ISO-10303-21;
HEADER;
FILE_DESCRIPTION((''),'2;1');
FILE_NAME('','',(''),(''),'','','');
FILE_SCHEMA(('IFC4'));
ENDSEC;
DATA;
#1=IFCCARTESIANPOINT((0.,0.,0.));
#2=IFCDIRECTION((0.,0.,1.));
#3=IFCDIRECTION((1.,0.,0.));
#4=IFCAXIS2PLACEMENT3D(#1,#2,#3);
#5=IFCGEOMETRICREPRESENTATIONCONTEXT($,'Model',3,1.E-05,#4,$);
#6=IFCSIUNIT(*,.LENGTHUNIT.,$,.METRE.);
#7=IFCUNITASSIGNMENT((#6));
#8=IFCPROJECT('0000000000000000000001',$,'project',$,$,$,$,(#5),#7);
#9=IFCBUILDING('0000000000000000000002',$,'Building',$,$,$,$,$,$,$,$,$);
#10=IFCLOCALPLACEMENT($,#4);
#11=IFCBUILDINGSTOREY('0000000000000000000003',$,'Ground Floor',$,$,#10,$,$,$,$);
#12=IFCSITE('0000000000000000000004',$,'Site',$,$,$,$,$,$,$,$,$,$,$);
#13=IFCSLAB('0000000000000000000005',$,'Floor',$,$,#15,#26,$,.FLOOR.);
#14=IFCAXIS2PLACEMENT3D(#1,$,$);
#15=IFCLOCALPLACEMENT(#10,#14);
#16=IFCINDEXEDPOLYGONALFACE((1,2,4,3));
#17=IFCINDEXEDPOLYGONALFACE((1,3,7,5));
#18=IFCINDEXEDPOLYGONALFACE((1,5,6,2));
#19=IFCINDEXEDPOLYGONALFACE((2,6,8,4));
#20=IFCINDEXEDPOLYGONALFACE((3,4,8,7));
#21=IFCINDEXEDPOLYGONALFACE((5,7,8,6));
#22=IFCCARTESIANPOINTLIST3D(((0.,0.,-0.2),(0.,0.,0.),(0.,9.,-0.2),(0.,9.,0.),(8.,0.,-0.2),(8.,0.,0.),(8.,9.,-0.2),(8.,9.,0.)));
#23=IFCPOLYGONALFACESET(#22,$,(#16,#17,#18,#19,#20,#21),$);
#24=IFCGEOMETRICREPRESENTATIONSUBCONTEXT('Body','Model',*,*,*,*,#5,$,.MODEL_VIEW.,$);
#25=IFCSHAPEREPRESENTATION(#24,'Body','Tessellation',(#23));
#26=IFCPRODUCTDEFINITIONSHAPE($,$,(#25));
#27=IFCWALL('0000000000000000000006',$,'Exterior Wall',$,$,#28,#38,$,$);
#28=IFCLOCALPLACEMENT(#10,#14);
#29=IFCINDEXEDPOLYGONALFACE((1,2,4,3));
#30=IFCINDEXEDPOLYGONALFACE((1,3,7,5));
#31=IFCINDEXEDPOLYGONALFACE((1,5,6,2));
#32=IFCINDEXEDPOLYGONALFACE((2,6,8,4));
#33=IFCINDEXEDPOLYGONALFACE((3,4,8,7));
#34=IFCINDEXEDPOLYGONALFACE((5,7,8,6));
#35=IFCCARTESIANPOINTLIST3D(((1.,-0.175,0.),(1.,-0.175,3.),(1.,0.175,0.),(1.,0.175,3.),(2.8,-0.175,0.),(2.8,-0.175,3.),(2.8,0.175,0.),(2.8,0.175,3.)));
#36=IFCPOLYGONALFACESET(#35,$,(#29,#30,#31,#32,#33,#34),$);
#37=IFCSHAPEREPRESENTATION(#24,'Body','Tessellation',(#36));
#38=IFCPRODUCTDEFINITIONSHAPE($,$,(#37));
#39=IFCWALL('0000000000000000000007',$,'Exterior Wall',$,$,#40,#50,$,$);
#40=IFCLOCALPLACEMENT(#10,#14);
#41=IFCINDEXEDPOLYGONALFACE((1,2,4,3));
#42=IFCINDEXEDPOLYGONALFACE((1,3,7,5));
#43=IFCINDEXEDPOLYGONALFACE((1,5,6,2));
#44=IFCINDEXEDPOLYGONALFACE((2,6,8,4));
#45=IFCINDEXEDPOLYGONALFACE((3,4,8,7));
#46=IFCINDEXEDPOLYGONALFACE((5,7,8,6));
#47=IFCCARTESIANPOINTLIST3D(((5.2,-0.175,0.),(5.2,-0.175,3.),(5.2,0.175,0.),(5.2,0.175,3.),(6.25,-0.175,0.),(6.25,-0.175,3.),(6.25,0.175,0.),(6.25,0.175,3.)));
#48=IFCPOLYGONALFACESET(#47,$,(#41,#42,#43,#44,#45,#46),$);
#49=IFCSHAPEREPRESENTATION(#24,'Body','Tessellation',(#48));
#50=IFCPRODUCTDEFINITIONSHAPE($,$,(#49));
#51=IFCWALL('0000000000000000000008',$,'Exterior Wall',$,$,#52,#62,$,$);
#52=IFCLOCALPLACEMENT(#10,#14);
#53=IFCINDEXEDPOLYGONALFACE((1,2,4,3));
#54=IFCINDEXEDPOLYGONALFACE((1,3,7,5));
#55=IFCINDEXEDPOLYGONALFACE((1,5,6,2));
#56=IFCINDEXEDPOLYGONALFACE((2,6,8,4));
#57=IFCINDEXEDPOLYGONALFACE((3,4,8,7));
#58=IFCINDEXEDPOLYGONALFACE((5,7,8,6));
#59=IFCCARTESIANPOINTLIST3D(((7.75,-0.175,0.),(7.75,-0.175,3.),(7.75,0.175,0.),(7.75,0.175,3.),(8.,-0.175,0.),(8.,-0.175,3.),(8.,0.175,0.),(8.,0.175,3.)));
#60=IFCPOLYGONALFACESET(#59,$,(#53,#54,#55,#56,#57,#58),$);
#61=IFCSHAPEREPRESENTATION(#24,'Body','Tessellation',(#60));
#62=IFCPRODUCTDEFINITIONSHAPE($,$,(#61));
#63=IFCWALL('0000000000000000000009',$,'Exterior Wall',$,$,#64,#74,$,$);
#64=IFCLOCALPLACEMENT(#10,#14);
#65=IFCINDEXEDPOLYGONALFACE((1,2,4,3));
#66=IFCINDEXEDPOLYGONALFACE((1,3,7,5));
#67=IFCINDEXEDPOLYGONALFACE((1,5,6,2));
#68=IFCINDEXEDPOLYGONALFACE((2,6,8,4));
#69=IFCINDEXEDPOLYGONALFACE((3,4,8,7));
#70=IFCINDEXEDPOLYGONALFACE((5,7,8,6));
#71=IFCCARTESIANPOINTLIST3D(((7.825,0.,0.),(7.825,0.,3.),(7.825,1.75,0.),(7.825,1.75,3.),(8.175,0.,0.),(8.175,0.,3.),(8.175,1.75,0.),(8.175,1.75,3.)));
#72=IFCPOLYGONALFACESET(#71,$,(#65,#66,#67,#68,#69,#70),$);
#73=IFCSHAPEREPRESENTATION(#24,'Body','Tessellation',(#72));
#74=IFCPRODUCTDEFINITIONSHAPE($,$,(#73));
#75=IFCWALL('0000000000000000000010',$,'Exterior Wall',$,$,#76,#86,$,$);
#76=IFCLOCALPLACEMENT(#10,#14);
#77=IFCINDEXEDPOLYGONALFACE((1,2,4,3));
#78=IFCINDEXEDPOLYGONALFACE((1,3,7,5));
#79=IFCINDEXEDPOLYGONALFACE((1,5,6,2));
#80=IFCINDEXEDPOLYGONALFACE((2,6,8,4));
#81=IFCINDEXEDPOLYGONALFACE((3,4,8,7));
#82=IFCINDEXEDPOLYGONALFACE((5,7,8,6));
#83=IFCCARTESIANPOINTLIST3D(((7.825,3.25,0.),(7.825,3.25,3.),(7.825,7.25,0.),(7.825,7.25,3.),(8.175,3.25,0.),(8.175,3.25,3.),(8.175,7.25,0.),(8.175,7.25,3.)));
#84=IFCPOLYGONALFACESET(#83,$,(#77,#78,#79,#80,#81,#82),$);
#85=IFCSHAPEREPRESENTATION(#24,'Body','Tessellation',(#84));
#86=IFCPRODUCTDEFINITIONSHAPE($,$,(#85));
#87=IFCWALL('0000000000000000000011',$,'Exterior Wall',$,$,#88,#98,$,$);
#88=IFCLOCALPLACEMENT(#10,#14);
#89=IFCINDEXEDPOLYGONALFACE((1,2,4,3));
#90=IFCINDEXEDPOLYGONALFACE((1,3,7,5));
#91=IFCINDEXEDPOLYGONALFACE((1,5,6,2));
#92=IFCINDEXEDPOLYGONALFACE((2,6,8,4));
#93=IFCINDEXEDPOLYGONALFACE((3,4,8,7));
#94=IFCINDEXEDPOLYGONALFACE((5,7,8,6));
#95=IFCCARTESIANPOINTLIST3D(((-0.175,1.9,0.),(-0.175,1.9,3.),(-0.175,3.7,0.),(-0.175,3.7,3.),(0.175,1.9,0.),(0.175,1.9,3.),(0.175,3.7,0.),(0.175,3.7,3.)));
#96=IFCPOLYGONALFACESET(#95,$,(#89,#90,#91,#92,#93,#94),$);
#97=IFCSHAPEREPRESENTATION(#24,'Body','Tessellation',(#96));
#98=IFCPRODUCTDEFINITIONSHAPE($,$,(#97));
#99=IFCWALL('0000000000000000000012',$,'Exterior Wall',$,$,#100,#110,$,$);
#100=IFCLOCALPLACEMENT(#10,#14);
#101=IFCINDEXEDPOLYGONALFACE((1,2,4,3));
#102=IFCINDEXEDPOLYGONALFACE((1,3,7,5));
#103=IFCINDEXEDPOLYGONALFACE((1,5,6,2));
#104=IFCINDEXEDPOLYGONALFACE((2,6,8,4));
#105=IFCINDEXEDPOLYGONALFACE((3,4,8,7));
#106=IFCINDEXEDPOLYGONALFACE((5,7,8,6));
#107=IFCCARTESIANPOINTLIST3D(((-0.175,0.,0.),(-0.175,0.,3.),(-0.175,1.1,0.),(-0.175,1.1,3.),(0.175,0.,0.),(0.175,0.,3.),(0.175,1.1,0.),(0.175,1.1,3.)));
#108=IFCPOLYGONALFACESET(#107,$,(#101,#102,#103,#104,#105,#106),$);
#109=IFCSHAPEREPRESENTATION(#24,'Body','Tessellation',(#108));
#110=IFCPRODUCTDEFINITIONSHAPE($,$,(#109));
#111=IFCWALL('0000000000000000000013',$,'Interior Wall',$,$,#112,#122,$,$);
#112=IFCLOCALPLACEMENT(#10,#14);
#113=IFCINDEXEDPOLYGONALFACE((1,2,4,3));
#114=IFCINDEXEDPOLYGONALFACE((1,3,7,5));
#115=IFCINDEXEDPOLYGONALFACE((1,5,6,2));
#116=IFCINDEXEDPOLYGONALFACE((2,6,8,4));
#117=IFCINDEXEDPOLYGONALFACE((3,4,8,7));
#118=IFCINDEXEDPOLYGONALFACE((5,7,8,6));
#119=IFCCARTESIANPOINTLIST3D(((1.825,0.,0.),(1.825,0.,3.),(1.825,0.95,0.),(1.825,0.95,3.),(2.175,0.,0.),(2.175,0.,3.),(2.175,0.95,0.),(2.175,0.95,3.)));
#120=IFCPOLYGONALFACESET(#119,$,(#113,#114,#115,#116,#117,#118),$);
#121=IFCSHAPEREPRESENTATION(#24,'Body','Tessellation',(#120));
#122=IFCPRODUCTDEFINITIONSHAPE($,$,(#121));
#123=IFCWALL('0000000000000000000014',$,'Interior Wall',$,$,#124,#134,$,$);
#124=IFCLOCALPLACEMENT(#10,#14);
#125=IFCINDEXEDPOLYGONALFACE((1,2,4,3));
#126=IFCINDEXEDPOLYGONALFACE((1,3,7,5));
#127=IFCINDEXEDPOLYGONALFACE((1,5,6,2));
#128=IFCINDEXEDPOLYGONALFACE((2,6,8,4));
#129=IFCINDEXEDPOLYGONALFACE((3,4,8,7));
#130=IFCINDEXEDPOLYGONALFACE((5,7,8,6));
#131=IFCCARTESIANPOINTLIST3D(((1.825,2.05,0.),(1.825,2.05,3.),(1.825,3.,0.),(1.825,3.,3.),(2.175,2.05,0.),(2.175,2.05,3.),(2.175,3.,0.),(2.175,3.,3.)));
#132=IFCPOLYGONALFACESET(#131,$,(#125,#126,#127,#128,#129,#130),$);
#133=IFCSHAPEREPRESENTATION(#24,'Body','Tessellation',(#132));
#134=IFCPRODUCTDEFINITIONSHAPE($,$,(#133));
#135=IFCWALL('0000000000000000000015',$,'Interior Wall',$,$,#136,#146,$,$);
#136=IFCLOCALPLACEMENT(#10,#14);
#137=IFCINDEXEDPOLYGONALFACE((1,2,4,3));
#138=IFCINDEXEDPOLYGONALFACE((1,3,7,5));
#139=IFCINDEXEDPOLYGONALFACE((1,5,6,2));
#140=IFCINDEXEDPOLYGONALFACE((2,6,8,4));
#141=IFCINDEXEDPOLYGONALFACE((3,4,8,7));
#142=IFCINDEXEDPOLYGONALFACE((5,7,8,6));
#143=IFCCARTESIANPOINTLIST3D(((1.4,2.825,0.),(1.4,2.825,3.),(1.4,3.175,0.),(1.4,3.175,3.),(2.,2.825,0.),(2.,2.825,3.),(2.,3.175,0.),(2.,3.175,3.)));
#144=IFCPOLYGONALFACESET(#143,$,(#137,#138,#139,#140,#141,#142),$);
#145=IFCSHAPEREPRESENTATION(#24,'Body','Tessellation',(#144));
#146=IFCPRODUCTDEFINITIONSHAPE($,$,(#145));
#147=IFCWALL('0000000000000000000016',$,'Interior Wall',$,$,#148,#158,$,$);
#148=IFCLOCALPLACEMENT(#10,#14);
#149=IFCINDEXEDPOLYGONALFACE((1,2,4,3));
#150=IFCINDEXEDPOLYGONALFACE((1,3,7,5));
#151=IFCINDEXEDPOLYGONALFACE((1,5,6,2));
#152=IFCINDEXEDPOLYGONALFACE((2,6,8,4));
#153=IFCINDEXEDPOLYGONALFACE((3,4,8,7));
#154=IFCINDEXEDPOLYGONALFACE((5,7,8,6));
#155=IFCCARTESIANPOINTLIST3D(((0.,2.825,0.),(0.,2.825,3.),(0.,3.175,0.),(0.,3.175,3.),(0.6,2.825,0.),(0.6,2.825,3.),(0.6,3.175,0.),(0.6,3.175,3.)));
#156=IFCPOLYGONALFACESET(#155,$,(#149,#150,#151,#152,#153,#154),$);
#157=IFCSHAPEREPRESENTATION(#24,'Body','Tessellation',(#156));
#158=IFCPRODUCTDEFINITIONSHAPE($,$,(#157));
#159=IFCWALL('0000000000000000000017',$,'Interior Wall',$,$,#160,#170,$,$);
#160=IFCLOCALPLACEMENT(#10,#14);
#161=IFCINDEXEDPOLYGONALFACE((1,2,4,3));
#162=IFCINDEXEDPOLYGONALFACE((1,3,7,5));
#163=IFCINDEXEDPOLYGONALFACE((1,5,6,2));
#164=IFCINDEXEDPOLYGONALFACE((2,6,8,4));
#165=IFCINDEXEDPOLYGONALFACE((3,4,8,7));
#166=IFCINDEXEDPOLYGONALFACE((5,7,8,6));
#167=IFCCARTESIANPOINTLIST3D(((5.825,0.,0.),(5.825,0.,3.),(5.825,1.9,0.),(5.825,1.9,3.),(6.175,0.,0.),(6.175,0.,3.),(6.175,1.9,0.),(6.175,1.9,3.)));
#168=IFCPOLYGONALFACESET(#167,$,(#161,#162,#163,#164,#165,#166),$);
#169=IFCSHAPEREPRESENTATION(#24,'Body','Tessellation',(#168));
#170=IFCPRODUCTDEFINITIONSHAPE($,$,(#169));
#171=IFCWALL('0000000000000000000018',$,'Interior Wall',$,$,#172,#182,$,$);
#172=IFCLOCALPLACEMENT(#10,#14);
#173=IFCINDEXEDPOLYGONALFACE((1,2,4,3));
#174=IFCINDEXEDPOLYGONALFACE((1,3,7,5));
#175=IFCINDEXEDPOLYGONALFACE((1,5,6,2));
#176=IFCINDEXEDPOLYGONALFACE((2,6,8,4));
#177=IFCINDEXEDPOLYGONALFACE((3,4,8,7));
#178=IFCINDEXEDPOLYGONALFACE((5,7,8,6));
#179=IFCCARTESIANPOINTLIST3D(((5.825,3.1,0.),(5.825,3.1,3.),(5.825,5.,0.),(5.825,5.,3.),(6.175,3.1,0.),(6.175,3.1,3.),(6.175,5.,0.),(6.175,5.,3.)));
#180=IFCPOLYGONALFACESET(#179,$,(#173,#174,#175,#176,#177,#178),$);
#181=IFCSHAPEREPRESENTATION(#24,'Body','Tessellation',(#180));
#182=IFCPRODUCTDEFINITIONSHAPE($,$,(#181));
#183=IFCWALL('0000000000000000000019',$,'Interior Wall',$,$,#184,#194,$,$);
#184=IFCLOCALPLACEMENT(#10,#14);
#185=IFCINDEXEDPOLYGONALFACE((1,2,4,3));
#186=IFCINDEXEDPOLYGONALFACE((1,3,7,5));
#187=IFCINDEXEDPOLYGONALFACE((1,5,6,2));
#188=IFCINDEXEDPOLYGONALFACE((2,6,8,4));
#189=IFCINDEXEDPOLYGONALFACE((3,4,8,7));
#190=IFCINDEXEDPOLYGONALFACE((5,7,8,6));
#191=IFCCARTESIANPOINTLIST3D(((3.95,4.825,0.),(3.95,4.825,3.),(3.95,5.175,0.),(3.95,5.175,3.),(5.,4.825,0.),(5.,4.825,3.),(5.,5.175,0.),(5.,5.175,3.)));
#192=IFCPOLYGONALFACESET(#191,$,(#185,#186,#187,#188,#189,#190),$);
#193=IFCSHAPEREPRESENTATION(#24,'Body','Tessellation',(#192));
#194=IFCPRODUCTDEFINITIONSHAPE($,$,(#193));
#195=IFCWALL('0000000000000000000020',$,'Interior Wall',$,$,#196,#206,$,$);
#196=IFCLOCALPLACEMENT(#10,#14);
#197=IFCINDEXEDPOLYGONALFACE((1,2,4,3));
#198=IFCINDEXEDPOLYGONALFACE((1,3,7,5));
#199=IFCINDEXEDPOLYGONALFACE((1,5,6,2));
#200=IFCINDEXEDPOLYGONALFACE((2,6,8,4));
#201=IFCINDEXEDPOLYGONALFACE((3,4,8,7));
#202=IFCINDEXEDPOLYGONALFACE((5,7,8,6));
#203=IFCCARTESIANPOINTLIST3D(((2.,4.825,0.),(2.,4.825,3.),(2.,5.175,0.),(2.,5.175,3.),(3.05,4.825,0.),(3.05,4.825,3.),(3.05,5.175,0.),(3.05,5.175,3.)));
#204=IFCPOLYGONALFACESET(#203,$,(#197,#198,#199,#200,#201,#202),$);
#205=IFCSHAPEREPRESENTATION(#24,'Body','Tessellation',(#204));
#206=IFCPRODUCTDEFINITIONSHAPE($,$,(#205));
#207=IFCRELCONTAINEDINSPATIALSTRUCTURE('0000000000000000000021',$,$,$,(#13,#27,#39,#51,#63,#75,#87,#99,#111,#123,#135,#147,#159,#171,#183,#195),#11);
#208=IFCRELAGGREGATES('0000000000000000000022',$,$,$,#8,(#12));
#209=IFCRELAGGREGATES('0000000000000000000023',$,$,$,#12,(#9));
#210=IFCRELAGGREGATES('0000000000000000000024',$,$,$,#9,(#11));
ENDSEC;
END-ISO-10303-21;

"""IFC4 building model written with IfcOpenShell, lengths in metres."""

from ifc_helpers import new_model, si_unit, frame, origin_with_axes, place, context, subcontext, project, spatial, indexed_curve, outline, extrude, element, save


model = new_model("IFC4")

# Units and contexts
model_context = context("Model", 3, precision=1e-05, world=origin_with_axes())
body_context = subcontext(model_context, "Body", "Model", "MODEL_VIEW")
ifc_project = project(units=[si_unit("LENGTHUNIT", "METRE")], contexts=[model_context])

# Site, building, storey
site = spatial("IfcSite", under=ifc_project, Name="Site")
building = spatial("IfcBuilding", under=site, Name="Building")
storey_placement = place(None, origin_with_axes())
storey = spatial("IfcBuildingStorey", under=building, at=storey_placement, Name="Ground Floor")

# Slab
slab_placement = place(storey_placement, frame((0.0, 0.0, -0.2), z_axis=(0.0, 0.0, 1.0), x_axis=(1.0, 0.0, 0.0)))
element("IfcSlab", 1, at=slab_placement, inside=storey, Name="Floor", PredefinedType="FLOOR", context=body_context, shape_type="SweptSolid", body=[
    extrude(outline(indexed_curve([(0.0, 0.0), (8.0, 0.0), (8.0, 9.0), (0.0, 9.0)])), None, (0.0, 0.0, 1.0), 0.2),
])

# Walls
wall_1_placement = place(storey_placement, frame((1.0, 0.0, 0.0), z_axis=(0.0, 0.0, 1.0), x_axis=(1.0, 0.0, 0.0)))
element("IfcWall", 2, at=wall_1_placement, inside=storey, Name="Exterior Wall", context=body_context, shape_type="SweptSolid", body=[
    extrude(outline(indexed_curve([(0.0, 0.0), (0.0, 0.35), (1.8, 0.35), (1.8, 0.0), (0.0, 0.0)], self_intersect=False)), frame((0.0, -0.175, 0.0), z_axis=(0.0, 0.0, 1.0), x_axis=(1.0, 0.0, 0.0)), (0.0, 0.0, 1.0), 3.0),
])
wall_2_placement = place(storey_placement, frame((5.2, 0.0, 0.0), z_axis=(0.0, 0.0, 1.0), x_axis=(1.0, 0.0, 0.0)))
element("IfcWall", 3, at=wall_2_placement, inside=storey, Name="Exterior Wall", context=body_context, shape_type="SweptSolid", body=[
    extrude(outline(indexed_curve([(0.0, 0.0), (0.0, 0.35), (1.05, 0.35), (1.05, 0.0), (0.0, 0.0)], self_intersect=False)), frame((0.0, -0.175, 0.0), z_axis=(0.0, 0.0, 1.0), x_axis=(1.0, 0.0, 0.0)), (0.0, 0.0, 1.0), 3.0),
])
wall_3_placement = place(storey_placement, frame((7.75, 0.0, 0.0), z_axis=(0.0, 0.0, 1.0), x_axis=(1.0, 0.0, 0.0)))
element("IfcWall", 4, at=wall_3_placement, inside=storey, Name="Exterior Wall", context=body_context, shape_type="SweptSolid", body=[
    extrude(outline(indexed_curve([(0.0, 0.0), (0.0, 0.35), (0.25, 0.35), (0.25, 0.0), (0.0, 0.0)], self_intersect=False)), frame((0.0, -0.175, 0.0), z_axis=(0.0, 0.0, 1.0), x_axis=(1.0, 0.0, 0.0)), (0.0, 0.0, 1.0), 3.0),
])
wall_4_placement = place(storey_placement, frame((8.0, 0.0, 0.0), z_axis=(0.0, 0.0, 1.0), x_axis=(0.0, 1.0, 0.0)))
element("IfcWall", 5, at=wall_4_placement, inside=storey, Name="Exterior Wall", context=body_context, shape_type="SweptSolid", body=[
    extrude(outline(indexed_curve([(0.0, 0.0), (0.0, 0.35), (1.75, 0.35), (1.75, 0.0), (0.0, 0.0)], self_intersect=False)), frame((0.0, -0.175, 0.0), z_axis=(0.0, 0.0, 1.0), x_axis=(1.0, 0.0, 0.0)), (0.0, 0.0, 1.0), 3.0),
])
wall_5_placement = place(storey_placement, frame((8.0, 3.25, 0.0), z_axis=(0.0, 0.0, 1.0), x_axis=(0.0, 1.0, 0.0)))
element("IfcWall", 6, at=wall_5_placement, inside=storey, Name="Exterior Wall", context=body_context, shape_type="SweptSolid", body=[
    extrude(outline(indexed_curve([(0.0, 0.0), (0.0, 0.35), (4.0, 0.35), (4.0, 0.0), (0.0, 0.0)], self_intersect=False)), frame((0.0, -0.175, 0.0), z_axis=(0.0, 0.0, 1.0), x_axis=(1.0, 0.0, 0.0)), (0.0, 0.0, 1.0), 3.0),
])
wall_6_placement = place(storey_placement, frame((0.0, 3.7, 0.0), z_axis=(0.0, 0.0, 1.0), x_axis=(0.0, -1.0, 0.0)))
element("IfcWall", 7, at=wall_6_placement, inside=storey, Name="Exterior Wall", context=body_context, shape_type="SweptSolid", body=[
    extrude(outline(indexed_curve([(0.0, 0.0), (0.0, 0.35), (1.8, 0.35), (1.8, 0.0), (0.0, 0.0)], self_intersect=False)), frame((0.0, -0.175, 0.0), z_axis=(0.0, 0.0, 1.0), x_axis=(1.0, 0.0, 0.0)), (0.0, 0.0, 1.0), 3.0),
])
wall_7_placement = place(storey_placement, frame((0.0, 1.1, 0.0), z_axis=(0.0, 0.0, 1.0), x_axis=(0.0, -1.0, 0.0)))
element("IfcWall", 8, at=wall_7_placement, inside=storey, Name="Exterior Wall", context=body_context, shape_type="SweptSolid", body=[
    extrude(outline(indexed_curve([(0.0, 0.0), (0.0, 0.35), (1.1, 0.35), (1.1, 0.0), (0.0, 0.0)], self_intersect=False)), frame((0.0, -0.175, 0.0), z_axis=(0.0, 0.0, 1.0), x_axis=(1.0, 0.0, 0.0)), (0.0, 0.0, 1.0), 3.0),
])
wall_8_placement = place(storey_placement, frame((2.0, 0.0, 0.0), z_axis=(0.0, 0.0, 1.0), x_axis=(0.0, 1.0, 0.0)))
element("IfcWall", 9, at=wall_8_placement, inside=storey, Name="Interior Wall", context=body_context, shape_type="SweptSolid", body=[
    extrude(outline(indexed_curve([(0.0, 0.0), (0.0, 0.35), (0.95, 0.35), (0.95, 0.0), (0.0, 0.0)], self_intersect=False)), frame((0.0, -0.175, 0.0), z_axis=(0.0, 0.0, 1.0), x_axis=(1.0, 0.0, 0.0)), (0.0, 0.0, 1.0), 3.0),
])
wall_9_placement = place(storey_placement, frame((2.0, 2.05, 0.0), z_axis=(0.0, 0.0, 1.0), x_axis=(0.0, 1.0, 0.0)))
element("IfcWall", 10, at=wall_9_placement, inside=storey, Name="Interior Wall", context=body_context, shape_type="SweptSolid", body=[
    extrude(outline(indexed_curve([(0.0, 0.0), (0.0, 0.35), (0.95, 0.35), (0.95, 0.0), (0.0, 0.0)], self_intersect=False)), frame((0.0, -0.175, 0.0), z_axis=(0.0, 0.0, 1.0), x_axis=(1.0, 0.0, 0.0)), (0.0, 0.0, 1.0), 3.0),
])
for number, where, z_axis, x_axis, name in (
    (11, (2.0, 3.0, 0.0), (0.0, 0.0, 1.0), (-1.0, 0.0, 0.0), "Interior Wall"),
    (12, (0.6, 3.0, 0.0), (0.0, 0.0, 1.0), (-1.0, 0.0, 0.0), "Interior Wall"),
):
    element("IfcWall", number, at=place(storey_placement, frame(where, z_axis=z_axis, x_axis=x_axis)), inside=storey, Name=name, context=body_context, shape_type="SweptSolid", body=[
        extrude(outline(indexed_curve([(0.0, 0.0), (0.0, 0.35), (0.6, 0.35), (0.6, 0.0), (0.0, 0.0)], self_intersect=False)), frame((0.0, -0.175, 0.0), z_axis=(0.0, 0.0, 1.0), x_axis=(1.0, 0.0, 0.0)), (0.0, 0.0, 1.0), 3.0),
    ])
for number, where, z_axis, x_axis, name in (
    (13, (6.0, 0.0, 0.0), (0.0, 0.0, 1.0), (0.0, 1.0, 0.0), "Interior Wall"),
    (14, (6.0, 3.1, 0.0), (0.0, 0.0, 1.0), (0.0, 1.0, 0.0), "Interior Wall"),
):
    element("IfcWall", number, at=place(storey_placement, frame(where, z_axis=z_axis, x_axis=x_axis)), inside=storey, Name=name, context=body_context, shape_type="SweptSolid", body=[
        extrude(outline(indexed_curve([(0.0, 0.0), (0.0, 0.35), (1.9, 0.35), (1.9, 0.0), (0.0, 0.0)], self_intersect=False)), frame((0.0, -0.175, 0.0), z_axis=(0.0, 0.0, 1.0), x_axis=(1.0, 0.0, 0.0)), (0.0, 0.0, 1.0), 3.0),
    ])
for number, where, z_axis, x_axis, name in (
    (15, (5.0, 5.0, 0.0), (0.0, 0.0, 1.0), (-1.0, 0.0, 0.0), "Interior Wall"),
    (16, (3.05, 5.0, 0.0), (0.0, 0.0, 1.0), (-1.0, 0.0, 0.0), "Interior Wall"),
):
    element("IfcWall", number, at=place(storey_placement, frame(where, z_axis=z_axis, x_axis=x_axis)), inside=storey, Name=name, context=body_context, shape_type="SweptSolid", body=[
        extrude(outline(indexed_curve([(0.0, 0.0), (0.0, 0.35), (1.05, 0.35), (1.05, 0.0), (0.0, 0.0)], self_intersect=False)), frame((0.0, -0.175, 0.0), z_axis=(0.0, 0.0, 1.0), x_axis=(1.0, 0.0, 0.0)), (0.0, 0.0, 1.0), 3.0),
    ])

save(model, "model.ifc")
